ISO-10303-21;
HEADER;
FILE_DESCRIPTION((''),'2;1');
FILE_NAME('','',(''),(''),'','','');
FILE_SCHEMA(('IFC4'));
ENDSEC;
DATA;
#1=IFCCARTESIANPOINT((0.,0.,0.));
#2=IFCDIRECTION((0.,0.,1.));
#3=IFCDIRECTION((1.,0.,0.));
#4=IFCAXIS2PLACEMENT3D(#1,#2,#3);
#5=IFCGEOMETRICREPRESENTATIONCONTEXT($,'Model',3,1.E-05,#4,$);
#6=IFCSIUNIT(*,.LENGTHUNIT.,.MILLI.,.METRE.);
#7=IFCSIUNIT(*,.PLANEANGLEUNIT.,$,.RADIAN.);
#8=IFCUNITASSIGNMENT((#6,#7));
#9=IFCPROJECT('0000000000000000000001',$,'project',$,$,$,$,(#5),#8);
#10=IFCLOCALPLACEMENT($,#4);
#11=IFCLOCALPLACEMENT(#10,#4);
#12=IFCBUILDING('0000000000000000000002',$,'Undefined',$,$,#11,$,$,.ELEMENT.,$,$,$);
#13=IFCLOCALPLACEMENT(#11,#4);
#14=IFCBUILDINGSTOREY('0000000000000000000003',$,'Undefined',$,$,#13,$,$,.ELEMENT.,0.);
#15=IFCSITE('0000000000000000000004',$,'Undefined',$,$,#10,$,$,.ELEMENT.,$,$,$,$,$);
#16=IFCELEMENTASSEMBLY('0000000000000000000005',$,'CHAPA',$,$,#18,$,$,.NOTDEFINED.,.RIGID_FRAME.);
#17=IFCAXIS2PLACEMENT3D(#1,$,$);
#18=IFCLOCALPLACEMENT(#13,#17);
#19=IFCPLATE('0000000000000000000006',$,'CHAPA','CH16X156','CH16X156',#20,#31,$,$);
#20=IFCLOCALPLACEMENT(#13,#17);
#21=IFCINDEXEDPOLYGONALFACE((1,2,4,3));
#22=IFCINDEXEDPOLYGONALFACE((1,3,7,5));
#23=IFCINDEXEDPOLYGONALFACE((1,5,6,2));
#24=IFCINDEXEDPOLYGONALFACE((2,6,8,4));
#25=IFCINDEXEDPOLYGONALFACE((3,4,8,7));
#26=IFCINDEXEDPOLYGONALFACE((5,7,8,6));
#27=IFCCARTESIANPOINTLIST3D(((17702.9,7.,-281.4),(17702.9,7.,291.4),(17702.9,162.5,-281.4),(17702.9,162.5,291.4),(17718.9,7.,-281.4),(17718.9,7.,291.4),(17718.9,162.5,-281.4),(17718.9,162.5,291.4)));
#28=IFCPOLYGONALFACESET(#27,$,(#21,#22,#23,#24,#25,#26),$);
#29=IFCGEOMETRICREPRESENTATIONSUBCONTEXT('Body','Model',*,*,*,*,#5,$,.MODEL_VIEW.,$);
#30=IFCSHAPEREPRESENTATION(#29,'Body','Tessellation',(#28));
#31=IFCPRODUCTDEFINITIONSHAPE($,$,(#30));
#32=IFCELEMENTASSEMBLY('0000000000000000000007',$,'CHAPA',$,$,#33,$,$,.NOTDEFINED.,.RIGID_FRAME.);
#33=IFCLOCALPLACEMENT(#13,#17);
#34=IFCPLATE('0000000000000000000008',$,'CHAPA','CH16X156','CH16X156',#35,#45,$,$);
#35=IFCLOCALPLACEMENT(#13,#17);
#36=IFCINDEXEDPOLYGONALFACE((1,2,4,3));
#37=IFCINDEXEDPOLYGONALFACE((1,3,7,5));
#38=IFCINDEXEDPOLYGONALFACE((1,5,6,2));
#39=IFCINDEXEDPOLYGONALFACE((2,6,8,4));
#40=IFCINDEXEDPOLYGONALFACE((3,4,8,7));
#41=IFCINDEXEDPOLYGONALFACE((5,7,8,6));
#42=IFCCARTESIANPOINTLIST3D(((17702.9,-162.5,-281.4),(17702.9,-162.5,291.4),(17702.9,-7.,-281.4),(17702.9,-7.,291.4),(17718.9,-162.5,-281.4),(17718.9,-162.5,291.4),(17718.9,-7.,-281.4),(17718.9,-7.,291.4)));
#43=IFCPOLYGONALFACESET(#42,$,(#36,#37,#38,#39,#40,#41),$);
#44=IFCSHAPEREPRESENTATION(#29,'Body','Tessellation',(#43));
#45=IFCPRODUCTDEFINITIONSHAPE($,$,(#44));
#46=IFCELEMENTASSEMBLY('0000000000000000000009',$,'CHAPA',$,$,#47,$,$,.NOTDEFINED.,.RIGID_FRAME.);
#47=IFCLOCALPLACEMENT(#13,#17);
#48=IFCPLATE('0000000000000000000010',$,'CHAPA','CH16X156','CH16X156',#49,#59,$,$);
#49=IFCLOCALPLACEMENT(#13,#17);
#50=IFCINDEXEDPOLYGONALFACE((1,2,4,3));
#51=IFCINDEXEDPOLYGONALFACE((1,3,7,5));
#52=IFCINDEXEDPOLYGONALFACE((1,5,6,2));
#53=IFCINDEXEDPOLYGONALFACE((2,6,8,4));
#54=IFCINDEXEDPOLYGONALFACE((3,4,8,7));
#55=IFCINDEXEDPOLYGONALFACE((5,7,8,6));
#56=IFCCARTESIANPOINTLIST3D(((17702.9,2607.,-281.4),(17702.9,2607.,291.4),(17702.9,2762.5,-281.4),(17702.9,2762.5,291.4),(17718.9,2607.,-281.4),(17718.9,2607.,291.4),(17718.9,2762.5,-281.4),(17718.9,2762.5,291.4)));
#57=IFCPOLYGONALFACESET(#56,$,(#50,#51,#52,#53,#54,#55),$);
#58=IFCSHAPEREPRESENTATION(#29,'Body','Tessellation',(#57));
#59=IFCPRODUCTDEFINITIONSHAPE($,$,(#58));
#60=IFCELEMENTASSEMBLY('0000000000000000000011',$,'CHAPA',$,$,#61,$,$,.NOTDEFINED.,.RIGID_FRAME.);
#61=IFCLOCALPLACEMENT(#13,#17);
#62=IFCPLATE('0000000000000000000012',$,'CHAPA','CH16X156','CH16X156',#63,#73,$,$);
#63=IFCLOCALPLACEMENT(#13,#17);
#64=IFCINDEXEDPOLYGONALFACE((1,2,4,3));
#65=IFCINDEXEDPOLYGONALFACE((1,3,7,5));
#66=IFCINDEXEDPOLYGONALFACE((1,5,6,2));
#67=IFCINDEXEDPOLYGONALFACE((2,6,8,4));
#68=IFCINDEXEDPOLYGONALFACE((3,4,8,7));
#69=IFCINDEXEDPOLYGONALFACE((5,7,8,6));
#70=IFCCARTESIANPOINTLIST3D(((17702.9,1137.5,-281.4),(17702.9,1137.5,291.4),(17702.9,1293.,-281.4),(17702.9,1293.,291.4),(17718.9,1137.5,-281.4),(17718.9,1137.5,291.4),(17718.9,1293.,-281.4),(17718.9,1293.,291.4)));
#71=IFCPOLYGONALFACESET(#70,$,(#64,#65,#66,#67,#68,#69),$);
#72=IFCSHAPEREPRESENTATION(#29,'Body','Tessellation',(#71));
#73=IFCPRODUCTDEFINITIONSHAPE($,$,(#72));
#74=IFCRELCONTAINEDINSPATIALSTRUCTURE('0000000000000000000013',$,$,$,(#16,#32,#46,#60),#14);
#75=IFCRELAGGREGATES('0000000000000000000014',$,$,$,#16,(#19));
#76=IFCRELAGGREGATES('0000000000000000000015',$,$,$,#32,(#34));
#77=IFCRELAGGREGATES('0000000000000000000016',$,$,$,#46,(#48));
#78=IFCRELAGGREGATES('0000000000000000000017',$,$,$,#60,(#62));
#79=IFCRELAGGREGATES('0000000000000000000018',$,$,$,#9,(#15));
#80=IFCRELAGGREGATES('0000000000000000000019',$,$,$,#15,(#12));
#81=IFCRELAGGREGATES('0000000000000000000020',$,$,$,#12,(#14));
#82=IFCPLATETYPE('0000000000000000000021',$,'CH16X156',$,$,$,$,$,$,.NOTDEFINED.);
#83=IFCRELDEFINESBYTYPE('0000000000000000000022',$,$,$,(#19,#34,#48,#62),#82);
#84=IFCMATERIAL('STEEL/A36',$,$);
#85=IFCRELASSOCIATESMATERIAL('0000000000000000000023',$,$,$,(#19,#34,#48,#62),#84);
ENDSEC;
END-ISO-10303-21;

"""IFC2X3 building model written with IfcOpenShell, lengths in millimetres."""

from ifc_helpers import new_model, si_unit, frame, origin_with_axes, place, context, subcontext, project, spatial, polyline, outline, extrude, material, type_object, element, aggregate, save


model = new_model("IFC2X3")

# Units and contexts
model_context = context("Model", 3, precision=1e-05, world=origin_with_axes())
body_context = subcontext(model_context, "Body", "Model", "MODEL_VIEW")
ifc_project = project(units=[si_unit("LENGTHUNIT", "METRE", prefix="MILLI"), si_unit("PLANEANGLEUNIT", "RADIAN")], contexts=[model_context])

# Site, building, storey
site_placement = place(None, origin_with_axes())
site = spatial("IfcSite", under=ifc_project, at=site_placement, Name="Undefined", CompositionType="ELEMENT")
building_placement = place(site_placement, origin_with_axes())
building = spatial("IfcBuilding", under=site, at=building_placement, Name="Undefined", CompositionType="ELEMENT")
storey_placement = place(building_placement, origin_with_axes())
storey = spatial("IfcBuildingStorey", under=building, at=storey_placement, Name="Undefined", CompositionType="ELEMENT", Elevation=0.0)

# Element assemblies, plates
ifc_material_1 = material(Name="STEEL/A36")
plate_type = type_object("IfcPlateType", Name="CH16X156", PredefinedType="NOTDEFINED")
assembly_1_placement = place(storey_placement, origin_with_axes())
assembly_1 = element("IfcElementAssembly", 1, at=assembly_1_placement, inside=storey, Name="CHAPA", AssemblyPlace="NOTDEFINED", PredefinedType="RIGID_FRAME")
plate_1_placement = place(assembly_1_placement, frame((17710.9, 162.5, 291.4), z_axis=(1.0, 0.0, 0.0), x_axis=(0.0, -1.0, 0.0)))
plate_1 = element("IfcPlate", 2, at=plate_1_placement, type_object=plate_type, material=ifc_material_1, Name="CHAPA", Description="CH16X156", ObjectType="CH16X156", context=body_context, shape_type="SweptSolid", body=[
    extrude(outline(polyline([(0.0, 0.0), (155.5, 0.0), (155.5, 572.8), (0.0, 572.8), (0.0, 0.0)])), frame((0.0, 0.0, -8.0), z_axis=(0.0, 0.0, 1.0), x_axis=(1.0, 0.0, 0.0)), (0.0, 0.0, 1.0), 16.0),
])
aggregate(assembly_1, [plate_1])
assembly_2_placement = place(storey_placement, origin_with_axes())
assembly_2 = element("IfcElementAssembly", 3, at=assembly_2_placement, inside=storey, Name="CHAPA", AssemblyPlace="NOTDEFINED", PredefinedType="RIGID_FRAME")
plate_2_placement = place(assembly_2_placement, frame((17710.9, -7.0, 291.4), z_axis=(1.0, 0.0, 0.0), x_axis=(0.0, -1.0, 0.0)))
plate_2 = element("IfcPlate", 4, at=plate_2_placement, type_object=plate_type, material=ifc_material_1, Name="CHAPA", Description="CH16X156", ObjectType="CH16X156", context=body_context, shape_type="SweptSolid", body=[
    extrude(outline(polyline([(0.0, 0.0), (155.5, 0.0), (155.5, 572.8), (0.0, 572.8), (0.0, 0.0)])), frame((0.0, 0.0, -8.0), z_axis=(0.0, 0.0, 1.0), x_axis=(1.0, 0.0, 0.0)), (0.0, 0.0, 1.0), 16.0),
])
aggregate(assembly_2, [plate_2])
assembly_3_placement = place(storey_placement, origin_with_axes())
assembly_3 = element("IfcElementAssembly", 5, at=assembly_3_placement, inside=storey, Name="CHAPA", AssemblyPlace="NOTDEFINED", PredefinedType="RIGID_FRAME")
plate_3_placement = place(assembly_3_placement, frame((17710.9, 2762.5, 291.4), z_axis=(1.0, 0.0, 0.0), x_axis=(0.0, -1.0, 0.0)))
plate_3 = element("IfcPlate", 6, at=plate_3_placement, type_object=plate_type, material=ifc_material_1, Name="CHAPA", Description="CH16X156", ObjectType="CH16X156", context=body_context, shape_type="SweptSolid", body=[
    extrude(outline(polyline([(0.0, 0.0), (155.5, 0.0), (155.5, 572.8), (0.0, 572.8), (0.0, 0.0)])), frame((0.0, 0.0, -8.0), z_axis=(0.0, 0.0, 1.0), x_axis=(1.0, 0.0, 0.0)), (0.0, 0.0, 1.0), 16.0),
])
aggregate(assembly_3, [plate_3])
assembly_4_placement = place(storey_placement, origin_with_axes())
assembly_4 = element("IfcElementAssembly", 7, at=assembly_4_placement, inside=storey, Name="CHAPA", AssemblyPlace="NOTDEFINED", PredefinedType="RIGID_FRAME")
plate_4_placement = place(assembly_4_placement, frame((17710.9, 1293.0, 291.4), z_axis=(1.0, 0.0, 0.0), x_axis=(0.0, -1.0, 0.0)))
plate_4 = element("IfcPlate", 8, at=plate_4_placement, type_object=plate_type, material=ifc_material_1, Name="CHAPA", Description="CH16X156", ObjectType="CH16X156", context=body_context, shape_type="SweptSolid", body=[
    extrude(outline(polyline([(0.0, 0.0), (155.5, 0.0), (155.5, 572.8), (0.0, 572.8), (0.0, 0.0)])), frame((0.0, 0.0, -8.0), z_axis=(0.0, 0.0, 1.0), x_axis=(1.0, 0.0, 0.0)), (0.0, 0.0, 1.0), 16.0),
])
aggregate(assembly_4, [plate_4])

save(model, "model.ifc")
